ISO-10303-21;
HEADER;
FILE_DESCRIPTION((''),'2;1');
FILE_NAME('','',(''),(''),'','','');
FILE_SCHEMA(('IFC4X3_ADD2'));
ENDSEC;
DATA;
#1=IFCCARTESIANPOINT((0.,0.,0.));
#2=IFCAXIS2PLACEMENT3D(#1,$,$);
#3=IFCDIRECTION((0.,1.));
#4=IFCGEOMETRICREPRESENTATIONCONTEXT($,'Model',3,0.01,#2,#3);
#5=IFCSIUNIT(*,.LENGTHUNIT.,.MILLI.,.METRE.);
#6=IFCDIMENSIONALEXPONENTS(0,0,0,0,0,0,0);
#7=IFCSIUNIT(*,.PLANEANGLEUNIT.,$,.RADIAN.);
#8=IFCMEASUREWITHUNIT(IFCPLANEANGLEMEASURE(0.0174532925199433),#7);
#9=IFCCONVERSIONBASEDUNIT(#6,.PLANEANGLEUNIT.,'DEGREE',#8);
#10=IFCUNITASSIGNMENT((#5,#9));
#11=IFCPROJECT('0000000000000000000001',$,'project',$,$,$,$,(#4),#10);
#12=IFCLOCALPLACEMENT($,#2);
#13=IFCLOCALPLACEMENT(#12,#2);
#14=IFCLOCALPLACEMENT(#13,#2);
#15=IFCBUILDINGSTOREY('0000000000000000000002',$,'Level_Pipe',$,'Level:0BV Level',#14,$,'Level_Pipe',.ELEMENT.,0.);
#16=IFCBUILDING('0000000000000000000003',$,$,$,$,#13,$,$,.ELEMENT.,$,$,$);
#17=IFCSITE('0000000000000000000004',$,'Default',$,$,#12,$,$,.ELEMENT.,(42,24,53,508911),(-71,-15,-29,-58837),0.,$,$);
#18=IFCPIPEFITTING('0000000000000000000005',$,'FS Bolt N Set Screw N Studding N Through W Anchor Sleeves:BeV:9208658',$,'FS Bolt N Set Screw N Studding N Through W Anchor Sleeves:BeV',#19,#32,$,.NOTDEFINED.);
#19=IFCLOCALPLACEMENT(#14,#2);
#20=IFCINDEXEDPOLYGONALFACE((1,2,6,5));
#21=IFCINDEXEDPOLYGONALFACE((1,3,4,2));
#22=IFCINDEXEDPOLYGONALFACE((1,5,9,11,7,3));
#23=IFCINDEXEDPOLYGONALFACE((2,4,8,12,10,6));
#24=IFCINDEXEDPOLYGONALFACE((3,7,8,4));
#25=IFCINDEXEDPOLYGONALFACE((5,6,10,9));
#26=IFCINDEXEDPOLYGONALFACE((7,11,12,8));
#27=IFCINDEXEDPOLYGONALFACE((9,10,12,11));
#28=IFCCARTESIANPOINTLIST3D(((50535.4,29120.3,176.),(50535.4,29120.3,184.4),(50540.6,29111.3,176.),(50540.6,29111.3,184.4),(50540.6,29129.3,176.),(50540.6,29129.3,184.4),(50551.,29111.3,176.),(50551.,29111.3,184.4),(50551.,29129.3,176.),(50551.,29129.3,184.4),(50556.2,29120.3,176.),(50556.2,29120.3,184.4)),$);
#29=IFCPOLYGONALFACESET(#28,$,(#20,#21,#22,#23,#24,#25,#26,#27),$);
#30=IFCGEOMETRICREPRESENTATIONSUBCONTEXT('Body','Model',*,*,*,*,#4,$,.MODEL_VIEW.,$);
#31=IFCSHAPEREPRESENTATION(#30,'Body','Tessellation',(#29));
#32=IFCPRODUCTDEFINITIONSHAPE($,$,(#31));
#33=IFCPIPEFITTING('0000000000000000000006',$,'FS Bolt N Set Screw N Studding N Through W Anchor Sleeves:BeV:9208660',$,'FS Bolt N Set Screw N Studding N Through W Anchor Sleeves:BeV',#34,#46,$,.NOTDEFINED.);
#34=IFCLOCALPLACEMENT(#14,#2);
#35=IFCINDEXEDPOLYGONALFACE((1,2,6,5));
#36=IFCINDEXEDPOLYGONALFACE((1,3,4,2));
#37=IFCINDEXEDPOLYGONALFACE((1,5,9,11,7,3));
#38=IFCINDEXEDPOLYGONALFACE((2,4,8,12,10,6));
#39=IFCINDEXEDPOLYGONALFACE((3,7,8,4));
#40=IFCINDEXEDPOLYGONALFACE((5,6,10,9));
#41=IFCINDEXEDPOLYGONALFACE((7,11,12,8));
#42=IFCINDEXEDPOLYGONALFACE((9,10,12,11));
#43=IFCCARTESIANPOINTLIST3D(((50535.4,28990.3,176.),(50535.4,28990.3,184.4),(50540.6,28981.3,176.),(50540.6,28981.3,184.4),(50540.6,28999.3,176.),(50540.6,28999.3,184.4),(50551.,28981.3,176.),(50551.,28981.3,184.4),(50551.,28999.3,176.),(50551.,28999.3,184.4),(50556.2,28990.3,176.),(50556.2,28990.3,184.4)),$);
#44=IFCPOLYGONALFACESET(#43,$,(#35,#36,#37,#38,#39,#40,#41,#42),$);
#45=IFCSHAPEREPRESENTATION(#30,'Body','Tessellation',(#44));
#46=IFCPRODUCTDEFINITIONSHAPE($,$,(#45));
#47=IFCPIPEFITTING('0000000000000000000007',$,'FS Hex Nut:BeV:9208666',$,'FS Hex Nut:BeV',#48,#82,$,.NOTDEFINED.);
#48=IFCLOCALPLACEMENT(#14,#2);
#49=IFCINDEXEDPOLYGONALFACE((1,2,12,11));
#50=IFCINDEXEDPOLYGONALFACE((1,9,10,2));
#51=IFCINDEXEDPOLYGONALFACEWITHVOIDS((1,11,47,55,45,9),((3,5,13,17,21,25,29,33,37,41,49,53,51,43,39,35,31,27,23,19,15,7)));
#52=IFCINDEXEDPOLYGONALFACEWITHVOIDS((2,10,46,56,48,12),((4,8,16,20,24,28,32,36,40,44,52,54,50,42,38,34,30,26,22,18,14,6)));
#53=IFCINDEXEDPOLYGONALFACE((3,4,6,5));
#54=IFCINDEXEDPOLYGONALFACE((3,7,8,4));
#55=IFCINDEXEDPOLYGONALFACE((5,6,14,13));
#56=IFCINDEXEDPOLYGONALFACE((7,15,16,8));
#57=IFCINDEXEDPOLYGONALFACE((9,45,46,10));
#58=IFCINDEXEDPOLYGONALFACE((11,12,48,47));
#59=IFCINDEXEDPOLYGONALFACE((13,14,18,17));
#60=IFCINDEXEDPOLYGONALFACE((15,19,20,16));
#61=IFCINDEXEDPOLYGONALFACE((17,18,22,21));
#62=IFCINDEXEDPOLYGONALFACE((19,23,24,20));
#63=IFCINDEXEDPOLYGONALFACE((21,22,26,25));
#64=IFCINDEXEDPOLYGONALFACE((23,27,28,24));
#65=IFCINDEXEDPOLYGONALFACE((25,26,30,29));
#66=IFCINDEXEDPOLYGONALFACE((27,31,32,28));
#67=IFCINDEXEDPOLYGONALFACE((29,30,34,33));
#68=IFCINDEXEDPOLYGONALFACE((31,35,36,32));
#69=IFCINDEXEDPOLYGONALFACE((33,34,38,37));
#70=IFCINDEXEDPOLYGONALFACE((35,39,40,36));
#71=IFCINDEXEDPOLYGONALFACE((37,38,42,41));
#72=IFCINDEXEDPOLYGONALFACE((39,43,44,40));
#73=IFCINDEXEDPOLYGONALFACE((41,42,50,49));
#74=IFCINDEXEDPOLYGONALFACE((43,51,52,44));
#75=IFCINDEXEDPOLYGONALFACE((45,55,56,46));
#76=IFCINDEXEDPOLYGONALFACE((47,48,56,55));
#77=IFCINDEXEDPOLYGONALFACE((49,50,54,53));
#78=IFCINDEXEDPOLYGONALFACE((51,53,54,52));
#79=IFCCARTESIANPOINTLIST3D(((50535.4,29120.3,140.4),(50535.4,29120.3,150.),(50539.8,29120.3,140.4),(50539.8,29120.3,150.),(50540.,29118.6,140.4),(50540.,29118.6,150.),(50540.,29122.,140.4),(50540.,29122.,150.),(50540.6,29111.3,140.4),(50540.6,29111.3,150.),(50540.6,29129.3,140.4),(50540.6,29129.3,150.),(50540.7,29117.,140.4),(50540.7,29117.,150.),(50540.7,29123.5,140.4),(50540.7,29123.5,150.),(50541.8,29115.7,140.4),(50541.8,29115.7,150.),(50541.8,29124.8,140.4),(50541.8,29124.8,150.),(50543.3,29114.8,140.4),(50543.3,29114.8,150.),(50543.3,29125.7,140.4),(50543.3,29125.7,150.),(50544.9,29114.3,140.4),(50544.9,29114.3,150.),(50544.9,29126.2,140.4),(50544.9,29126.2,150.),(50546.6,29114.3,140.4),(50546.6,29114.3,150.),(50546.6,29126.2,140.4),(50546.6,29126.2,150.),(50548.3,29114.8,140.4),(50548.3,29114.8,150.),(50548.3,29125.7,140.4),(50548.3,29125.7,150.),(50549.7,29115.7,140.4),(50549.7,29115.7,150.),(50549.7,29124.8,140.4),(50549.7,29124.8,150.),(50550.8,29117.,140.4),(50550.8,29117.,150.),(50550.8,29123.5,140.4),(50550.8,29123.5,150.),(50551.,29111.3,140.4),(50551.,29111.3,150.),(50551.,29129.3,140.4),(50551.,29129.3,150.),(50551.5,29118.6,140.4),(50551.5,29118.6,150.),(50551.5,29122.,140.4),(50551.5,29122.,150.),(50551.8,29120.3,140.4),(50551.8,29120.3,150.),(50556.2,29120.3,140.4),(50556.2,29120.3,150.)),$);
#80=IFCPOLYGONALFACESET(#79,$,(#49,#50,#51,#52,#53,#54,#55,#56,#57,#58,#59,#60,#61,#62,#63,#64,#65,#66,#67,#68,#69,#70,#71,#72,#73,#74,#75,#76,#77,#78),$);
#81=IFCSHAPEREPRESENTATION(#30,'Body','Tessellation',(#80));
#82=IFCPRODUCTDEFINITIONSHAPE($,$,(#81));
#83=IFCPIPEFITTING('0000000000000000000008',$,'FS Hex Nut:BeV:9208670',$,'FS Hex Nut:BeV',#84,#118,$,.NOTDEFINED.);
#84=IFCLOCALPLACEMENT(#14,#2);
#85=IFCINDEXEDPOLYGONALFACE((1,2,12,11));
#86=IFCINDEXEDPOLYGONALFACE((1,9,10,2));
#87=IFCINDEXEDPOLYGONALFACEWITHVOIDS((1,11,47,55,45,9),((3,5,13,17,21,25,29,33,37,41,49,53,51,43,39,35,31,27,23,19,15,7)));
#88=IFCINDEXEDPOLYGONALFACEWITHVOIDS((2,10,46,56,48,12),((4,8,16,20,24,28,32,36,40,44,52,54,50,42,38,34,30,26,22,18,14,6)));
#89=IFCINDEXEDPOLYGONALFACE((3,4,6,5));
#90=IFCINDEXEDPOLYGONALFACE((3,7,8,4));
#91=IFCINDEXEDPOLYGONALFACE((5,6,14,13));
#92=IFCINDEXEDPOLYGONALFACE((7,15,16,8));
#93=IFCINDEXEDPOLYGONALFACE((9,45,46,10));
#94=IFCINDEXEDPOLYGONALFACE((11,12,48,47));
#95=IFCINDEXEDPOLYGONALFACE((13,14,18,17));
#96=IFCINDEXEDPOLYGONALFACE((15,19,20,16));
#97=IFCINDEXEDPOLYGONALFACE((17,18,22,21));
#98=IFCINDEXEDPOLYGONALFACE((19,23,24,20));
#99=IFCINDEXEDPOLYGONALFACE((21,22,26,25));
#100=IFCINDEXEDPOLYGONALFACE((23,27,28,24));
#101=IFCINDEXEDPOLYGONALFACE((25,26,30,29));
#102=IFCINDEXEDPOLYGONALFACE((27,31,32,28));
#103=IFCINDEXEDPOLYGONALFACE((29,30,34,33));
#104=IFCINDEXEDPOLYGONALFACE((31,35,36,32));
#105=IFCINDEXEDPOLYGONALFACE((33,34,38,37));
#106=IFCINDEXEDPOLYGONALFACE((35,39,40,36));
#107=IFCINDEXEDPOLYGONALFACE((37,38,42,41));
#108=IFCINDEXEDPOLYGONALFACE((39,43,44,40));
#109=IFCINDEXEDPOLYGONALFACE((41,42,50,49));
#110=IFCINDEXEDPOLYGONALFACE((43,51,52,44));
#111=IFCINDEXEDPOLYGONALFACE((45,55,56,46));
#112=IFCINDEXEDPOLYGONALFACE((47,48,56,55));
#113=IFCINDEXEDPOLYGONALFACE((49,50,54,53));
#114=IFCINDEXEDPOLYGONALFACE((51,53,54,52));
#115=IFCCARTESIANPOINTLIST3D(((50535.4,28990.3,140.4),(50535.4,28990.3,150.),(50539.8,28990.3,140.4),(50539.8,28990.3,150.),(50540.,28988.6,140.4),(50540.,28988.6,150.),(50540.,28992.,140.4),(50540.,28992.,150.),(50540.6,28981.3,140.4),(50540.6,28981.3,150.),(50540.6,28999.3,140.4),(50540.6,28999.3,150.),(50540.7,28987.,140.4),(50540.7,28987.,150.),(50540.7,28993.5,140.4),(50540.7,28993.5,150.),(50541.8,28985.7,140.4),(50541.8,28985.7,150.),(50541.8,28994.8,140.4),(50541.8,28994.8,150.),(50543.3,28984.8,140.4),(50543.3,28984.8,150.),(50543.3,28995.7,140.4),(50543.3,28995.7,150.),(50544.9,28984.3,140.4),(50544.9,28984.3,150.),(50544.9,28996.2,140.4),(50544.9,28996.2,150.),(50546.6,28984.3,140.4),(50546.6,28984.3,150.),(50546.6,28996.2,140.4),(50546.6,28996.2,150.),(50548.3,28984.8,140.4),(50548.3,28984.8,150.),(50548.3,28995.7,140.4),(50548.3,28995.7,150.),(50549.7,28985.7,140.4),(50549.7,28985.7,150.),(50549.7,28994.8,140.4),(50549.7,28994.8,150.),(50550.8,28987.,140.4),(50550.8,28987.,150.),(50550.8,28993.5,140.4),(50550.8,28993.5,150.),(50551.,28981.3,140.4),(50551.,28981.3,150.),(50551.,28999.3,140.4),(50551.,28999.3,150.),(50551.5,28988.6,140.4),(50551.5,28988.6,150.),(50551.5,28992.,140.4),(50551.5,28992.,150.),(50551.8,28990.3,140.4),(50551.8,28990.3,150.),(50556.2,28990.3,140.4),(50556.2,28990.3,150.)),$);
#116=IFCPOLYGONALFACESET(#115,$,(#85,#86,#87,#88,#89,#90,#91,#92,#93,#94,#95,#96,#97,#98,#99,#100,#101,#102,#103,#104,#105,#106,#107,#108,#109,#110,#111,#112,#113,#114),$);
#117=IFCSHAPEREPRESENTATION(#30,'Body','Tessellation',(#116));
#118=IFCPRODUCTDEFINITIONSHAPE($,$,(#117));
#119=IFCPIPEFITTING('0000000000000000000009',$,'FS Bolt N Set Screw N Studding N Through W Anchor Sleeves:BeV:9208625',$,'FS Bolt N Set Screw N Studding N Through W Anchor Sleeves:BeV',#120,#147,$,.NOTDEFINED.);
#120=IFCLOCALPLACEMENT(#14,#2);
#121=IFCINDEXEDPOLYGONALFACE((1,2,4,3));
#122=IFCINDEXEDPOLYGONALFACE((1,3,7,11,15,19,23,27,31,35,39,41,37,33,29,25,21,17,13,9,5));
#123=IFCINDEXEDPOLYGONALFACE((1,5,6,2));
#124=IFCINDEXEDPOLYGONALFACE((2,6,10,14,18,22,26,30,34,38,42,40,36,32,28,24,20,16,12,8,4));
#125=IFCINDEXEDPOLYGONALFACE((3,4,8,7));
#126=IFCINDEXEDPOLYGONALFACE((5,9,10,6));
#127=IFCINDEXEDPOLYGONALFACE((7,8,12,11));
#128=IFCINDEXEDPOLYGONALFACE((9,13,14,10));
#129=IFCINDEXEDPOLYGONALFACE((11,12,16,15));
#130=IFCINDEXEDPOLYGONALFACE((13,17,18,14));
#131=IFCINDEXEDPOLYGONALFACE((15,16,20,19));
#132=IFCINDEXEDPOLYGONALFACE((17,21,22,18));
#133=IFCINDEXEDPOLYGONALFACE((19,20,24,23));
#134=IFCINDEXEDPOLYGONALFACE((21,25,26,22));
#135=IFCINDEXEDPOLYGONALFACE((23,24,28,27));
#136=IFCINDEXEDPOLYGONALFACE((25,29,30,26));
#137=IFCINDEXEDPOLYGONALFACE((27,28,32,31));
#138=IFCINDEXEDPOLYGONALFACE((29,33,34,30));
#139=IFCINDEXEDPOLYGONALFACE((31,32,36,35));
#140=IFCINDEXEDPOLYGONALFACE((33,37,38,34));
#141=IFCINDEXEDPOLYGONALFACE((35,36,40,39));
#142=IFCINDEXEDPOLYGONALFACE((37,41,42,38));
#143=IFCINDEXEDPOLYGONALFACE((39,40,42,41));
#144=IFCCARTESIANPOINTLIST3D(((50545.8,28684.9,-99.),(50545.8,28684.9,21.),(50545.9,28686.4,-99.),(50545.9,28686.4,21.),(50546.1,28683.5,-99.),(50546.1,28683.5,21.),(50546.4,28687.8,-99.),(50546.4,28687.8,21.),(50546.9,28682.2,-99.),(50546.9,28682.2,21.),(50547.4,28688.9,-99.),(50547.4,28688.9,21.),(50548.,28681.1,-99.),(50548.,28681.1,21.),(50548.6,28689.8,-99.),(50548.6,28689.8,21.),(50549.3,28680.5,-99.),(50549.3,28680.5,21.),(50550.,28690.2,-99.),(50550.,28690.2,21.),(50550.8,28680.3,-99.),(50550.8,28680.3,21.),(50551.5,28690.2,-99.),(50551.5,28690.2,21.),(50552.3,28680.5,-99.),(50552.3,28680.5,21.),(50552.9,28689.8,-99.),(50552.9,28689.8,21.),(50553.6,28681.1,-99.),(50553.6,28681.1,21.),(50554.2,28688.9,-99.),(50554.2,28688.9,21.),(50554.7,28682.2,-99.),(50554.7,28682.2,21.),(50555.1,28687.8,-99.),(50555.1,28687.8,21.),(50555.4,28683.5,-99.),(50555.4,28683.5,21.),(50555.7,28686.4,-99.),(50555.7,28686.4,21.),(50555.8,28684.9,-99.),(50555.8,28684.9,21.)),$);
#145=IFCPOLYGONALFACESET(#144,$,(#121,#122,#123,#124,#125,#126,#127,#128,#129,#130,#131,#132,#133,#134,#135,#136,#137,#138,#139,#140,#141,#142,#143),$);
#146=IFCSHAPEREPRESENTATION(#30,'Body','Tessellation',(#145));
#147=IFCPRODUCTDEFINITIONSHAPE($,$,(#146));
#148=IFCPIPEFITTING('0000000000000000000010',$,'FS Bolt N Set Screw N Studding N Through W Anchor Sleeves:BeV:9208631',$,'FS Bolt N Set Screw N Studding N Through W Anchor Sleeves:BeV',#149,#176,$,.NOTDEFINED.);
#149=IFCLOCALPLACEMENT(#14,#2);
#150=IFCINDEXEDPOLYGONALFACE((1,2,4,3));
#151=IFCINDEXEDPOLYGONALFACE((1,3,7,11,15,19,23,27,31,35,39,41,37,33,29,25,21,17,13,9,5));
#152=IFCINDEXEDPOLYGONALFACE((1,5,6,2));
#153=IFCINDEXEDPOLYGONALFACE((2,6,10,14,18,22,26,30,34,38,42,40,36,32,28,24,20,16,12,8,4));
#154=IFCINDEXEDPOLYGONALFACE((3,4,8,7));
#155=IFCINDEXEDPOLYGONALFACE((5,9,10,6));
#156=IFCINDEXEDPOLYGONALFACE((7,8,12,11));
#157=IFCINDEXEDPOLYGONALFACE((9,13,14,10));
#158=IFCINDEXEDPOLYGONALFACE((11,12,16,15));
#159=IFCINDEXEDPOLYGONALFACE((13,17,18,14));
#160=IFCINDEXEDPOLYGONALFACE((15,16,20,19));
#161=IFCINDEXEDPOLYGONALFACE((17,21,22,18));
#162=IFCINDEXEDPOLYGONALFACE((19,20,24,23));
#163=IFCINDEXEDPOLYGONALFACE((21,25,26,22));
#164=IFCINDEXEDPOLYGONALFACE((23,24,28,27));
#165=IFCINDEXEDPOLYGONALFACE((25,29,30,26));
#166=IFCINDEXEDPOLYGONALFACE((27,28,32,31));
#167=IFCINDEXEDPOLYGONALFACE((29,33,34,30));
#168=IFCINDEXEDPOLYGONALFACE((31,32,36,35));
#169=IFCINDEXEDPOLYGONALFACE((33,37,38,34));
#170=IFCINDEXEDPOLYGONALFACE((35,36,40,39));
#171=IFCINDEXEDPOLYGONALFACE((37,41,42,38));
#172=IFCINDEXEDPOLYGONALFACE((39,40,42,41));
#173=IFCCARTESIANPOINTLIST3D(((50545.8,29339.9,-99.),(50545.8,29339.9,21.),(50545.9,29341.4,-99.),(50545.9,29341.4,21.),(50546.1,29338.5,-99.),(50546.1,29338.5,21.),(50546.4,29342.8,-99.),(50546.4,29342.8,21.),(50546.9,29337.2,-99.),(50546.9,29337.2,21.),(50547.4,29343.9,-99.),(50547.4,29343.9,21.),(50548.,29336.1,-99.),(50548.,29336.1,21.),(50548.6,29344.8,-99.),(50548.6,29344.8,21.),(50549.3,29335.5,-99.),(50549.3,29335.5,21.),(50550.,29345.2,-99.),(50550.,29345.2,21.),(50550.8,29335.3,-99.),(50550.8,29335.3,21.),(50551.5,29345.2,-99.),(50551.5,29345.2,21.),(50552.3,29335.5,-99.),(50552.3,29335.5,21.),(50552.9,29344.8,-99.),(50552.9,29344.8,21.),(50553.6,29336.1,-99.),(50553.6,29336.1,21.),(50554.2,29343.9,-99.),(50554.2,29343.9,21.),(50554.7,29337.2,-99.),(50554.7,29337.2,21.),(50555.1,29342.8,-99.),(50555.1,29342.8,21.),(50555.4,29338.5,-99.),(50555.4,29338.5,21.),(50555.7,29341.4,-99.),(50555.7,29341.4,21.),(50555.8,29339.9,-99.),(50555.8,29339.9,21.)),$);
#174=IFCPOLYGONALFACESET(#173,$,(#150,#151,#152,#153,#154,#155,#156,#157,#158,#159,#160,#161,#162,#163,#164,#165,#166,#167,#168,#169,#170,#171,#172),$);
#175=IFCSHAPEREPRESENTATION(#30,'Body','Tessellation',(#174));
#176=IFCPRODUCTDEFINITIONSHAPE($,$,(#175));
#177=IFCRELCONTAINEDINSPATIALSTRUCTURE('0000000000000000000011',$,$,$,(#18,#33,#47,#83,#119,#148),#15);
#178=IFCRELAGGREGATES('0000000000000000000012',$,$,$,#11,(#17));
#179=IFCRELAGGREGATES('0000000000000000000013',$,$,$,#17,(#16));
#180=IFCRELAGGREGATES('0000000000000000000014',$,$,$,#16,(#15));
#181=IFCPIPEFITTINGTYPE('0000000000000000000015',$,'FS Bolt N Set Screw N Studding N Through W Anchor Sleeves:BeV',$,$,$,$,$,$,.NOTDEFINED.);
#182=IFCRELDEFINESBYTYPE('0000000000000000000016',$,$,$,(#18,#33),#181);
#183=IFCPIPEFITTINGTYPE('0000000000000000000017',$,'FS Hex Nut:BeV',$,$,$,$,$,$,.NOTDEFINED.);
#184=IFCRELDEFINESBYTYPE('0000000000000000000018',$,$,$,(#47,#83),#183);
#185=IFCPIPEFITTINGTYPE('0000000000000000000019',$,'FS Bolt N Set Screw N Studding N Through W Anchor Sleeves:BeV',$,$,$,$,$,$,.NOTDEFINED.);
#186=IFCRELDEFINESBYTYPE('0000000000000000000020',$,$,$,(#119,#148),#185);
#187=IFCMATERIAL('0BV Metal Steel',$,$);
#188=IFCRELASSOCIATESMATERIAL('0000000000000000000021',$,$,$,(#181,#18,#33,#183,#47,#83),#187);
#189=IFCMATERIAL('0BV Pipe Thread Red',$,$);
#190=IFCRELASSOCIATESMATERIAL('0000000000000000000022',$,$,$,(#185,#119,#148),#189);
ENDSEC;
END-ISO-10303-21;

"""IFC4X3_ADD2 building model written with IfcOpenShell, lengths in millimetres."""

from ifc_helpers import new_model, entity, si_unit, converted_unit, direction, frame, frame_2d, origin, place, context, subcontext, project, spatial, polyline, circle_curve, parameter, trimmed, segment, composite_curve, circle, outline, extrude, source, transform, mapped, material, type_object, type_shapes, element, save


model = new_model("IFC4X3_ADD2")

# Units and contexts
model_context = context("Model", 3, precision=0.01, world=origin(), true_north=direction((0.0, 1.0)))
body_context = subcontext(model_context, "Body", "Model", "MODEL_VIEW")
ifc_project = project(units=[si_unit("LENGTHUNIT", "METRE", prefix="MILLI"), converted_unit("PLANEANGLEUNIT", "DEGREE", entity("IfcPlaneAngleMeasure", 0.0174532925199433), si_unit("PLANEANGLEUNIT", "RADIAN"), dimensions=[0, 0, 0, 0, 0, 0, 0])], contexts=[model_context])

# Site, building, storey
site_placement = place(None, origin())
site = spatial("IfcSite", under=ifc_project, at=site_placement, Name="Default", CompositionType="ELEMENT", RefLatitude=(42, 24, 53, 508911), RefLongitude=(-71, -15, -29, -58837), RefElevation=0.0)
building_placement = place(site_placement, origin())
building = spatial("IfcBuilding", under=site, at=building_placement, CompositionType="ELEMENT")
storey_placement = place(building_placement, origin())
storey = spatial("IfcBuildingStorey", under=building, at=storey_placement, Name="Level_Pipe", ObjectType="Level:0BV Level", LongName="Level_Pipe", CompositionType="ELEMENT", Elevation=0.0)

# Pipe fittings
ifc_material_1 = material(Name="0BV Metal Steel")
pipe_fitting_type_1 = type_object("IfcPipeFittingType", Name="FS Bolt N Set Screw N Studding N Through W Anchor Sleeves:BeV", PredefinedType="NOTDEFINED", material=ifc_material_1)
shared_shape_1 = source(origin(), body_context, "Body", "SweptSolid", [
    extrude(outline(polyline([(-5.2, -9.0), (5.2, -9.0), (10.4, 0.0), (5.2, 9.0), (-5.2, 9.0), (-10.4, 0.0), (-5.2, -9.0)])), frame((-8.4, 0.0, 0.0), z_axis=(1.0, 0.0, 0.0), x_axis=(0.0, -0.5, -0.866025)), (0.0, 0.0, 1.0), 8.4),
])
type_shapes(pipe_fitting_type_1, [shared_shape_1])
for number, where, z_axis, x_axis, name in (
    (1, (50545.8, 29120.3, 176.0), (0.0, 1.0, 0.0), (0.0, 0.0, -1.0), "FS Bolt N Set Screw N Studding N Through W Anchor Sleeves:BeV:9208658"),
    (2, (50545.8, 28990.3, 176.0), (0.0, 1.0, 0.0), (0.0, 0.0, -1.0), "FS Bolt N Set Screw N Studding N Through W Anchor Sleeves:BeV:9208660"),
):
    element("IfcPipeFitting", number, at=place(storey_placement, frame(where, z_axis=z_axis, x_axis=x_axis)), inside=storey, type_object=pipe_fitting_type_1, material=ifc_material_1, Name=name, ObjectType="FS Bolt N Set Screw N Studding N Through W Anchor Sleeves:BeV", PredefinedType="NOTDEFINED", context=body_context, shape_type="MappedRepresentation", body=[
        mapped(shared_shape_1, transform((0.0, 0.0, 0.0), scale=1.0)),
    ])
pipe_fitting_type_2 = type_object("IfcPipeFittingType", Name="FS Hex Nut:BeV", PredefinedType="NOTDEFINED", material=ifc_material_1)
shared_shape_2 = source(origin(), body_context, "Body", "SweptSolid", [
    extrude(outline(polyline([(-5.2, -9.0), (5.2, -9.0), (10.4, 0.0), (5.2, 9.0), (-5.2, 9.0), (-10.4, 0.0), (-5.2, -9.0)]), holes=[composite_curve([segment(trimmed(circle_curve(frame_2d((0.0, 0.0), x_axis=(-0.5, 0.866025)), 6.0), [parameter(0.0)], [parameter(180.0)], True, "PARAMETER"), False, "CONTINUOUS"), segment(trimmed(circle_curve(frame_2d((0.0, 0.0), x_axis=(-0.5, 0.866025)), 6.0), [parameter(180.0)], [parameter(360.0)], True, "PARAMETER"), False, "CONTINUOUS")], self_intersect=False)]), frame((0.0, 10.4, 9.0), z_axis=(1.0, 0.0, 0.0), x_axis=(0.0, -0.5, -0.866025)), (0.0, 0.0, 1.0), 9.6),
])
type_shapes(pipe_fitting_type_2, [shared_shape_2])
for number, where, z_axis, x_axis, name in (
    (3, (50556.2, 29111.3, 150.0), (0.0, 1.0, 0.0), (0.0, 0.0, -1.0), "FS Hex Nut:BeV:9208666"),
    (4, (50556.2, 28981.3, 150.0), (0.0, 1.0, 0.0), (0.0, 0.0, -1.0), "FS Hex Nut:BeV:9208670"),
):
    element("IfcPipeFitting", number, at=place(storey_placement, frame(where, z_axis=z_axis, x_axis=x_axis)), inside=storey, type_object=pipe_fitting_type_2, material=ifc_material_1, Name=name, ObjectType="FS Hex Nut:BeV", PredefinedType="NOTDEFINED", context=body_context, shape_type="MappedRepresentation", body=[
        mapped(shared_shape_2, transform((0.0, 0.0, 0.0), scale=1.0)),
    ])
ifc_material_2 = material(Name="0BV Pipe Thread Red")
pipe_fitting_type_3 = type_object("IfcPipeFittingType", Name="FS Bolt N Set Screw N Studding N Through W Anchor Sleeves:BeV", PredefinedType="NOTDEFINED", material=ifc_material_2)
shared_shape_3 = source(origin(), body_context, "Body", "SweptSolid", [
    extrude(circle(Radius=5.0, at=frame_2d((0.0, 0.0), x_axis=(1.0, 0.0))), frame((-16.0, 0.0, 0.0), z_axis=(1.0, 0.0, 0.0), x_axis=(0.0, 1.0, 0.0)), (0.0, 0.0, 1.0), 120.0),
])
type_shapes(pipe_fitting_type_3, [shared_shape_3])
for number, where, z_axis, x_axis, name in (
    (5, (50550.8, 28685.3, 5.0), (-1.0, 0.0, 0.0), (0.0, 0.0, -1.0), "FS Bolt N Set Screw N Studding N Through W Anchor Sleeves:BeV:9208625"),
    (6, (50550.8, 29340.3, 5.0), (-1.0, 0.0, 0.0), (0.0, 0.0, -1.0), "FS Bolt N Set Screw N Studding N Through W Anchor Sleeves:BeV:9208631"),
):
    element("IfcPipeFitting", number, at=place(storey_placement, frame(where, z_axis=z_axis, x_axis=x_axis)), inside=storey, type_object=pipe_fitting_type_3, material=ifc_material_2, Name=name, ObjectType="FS Bolt N Set Screw N Studding N Through W Anchor Sleeves:BeV", PredefinedType="NOTDEFINED", context=body_context, shape_type="MappedRepresentation", body=[
        mapped(shared_shape_3, transform((0.0, 0.0, 0.0), scale=1.0)),
    ])

save(model, "model.ifc")
